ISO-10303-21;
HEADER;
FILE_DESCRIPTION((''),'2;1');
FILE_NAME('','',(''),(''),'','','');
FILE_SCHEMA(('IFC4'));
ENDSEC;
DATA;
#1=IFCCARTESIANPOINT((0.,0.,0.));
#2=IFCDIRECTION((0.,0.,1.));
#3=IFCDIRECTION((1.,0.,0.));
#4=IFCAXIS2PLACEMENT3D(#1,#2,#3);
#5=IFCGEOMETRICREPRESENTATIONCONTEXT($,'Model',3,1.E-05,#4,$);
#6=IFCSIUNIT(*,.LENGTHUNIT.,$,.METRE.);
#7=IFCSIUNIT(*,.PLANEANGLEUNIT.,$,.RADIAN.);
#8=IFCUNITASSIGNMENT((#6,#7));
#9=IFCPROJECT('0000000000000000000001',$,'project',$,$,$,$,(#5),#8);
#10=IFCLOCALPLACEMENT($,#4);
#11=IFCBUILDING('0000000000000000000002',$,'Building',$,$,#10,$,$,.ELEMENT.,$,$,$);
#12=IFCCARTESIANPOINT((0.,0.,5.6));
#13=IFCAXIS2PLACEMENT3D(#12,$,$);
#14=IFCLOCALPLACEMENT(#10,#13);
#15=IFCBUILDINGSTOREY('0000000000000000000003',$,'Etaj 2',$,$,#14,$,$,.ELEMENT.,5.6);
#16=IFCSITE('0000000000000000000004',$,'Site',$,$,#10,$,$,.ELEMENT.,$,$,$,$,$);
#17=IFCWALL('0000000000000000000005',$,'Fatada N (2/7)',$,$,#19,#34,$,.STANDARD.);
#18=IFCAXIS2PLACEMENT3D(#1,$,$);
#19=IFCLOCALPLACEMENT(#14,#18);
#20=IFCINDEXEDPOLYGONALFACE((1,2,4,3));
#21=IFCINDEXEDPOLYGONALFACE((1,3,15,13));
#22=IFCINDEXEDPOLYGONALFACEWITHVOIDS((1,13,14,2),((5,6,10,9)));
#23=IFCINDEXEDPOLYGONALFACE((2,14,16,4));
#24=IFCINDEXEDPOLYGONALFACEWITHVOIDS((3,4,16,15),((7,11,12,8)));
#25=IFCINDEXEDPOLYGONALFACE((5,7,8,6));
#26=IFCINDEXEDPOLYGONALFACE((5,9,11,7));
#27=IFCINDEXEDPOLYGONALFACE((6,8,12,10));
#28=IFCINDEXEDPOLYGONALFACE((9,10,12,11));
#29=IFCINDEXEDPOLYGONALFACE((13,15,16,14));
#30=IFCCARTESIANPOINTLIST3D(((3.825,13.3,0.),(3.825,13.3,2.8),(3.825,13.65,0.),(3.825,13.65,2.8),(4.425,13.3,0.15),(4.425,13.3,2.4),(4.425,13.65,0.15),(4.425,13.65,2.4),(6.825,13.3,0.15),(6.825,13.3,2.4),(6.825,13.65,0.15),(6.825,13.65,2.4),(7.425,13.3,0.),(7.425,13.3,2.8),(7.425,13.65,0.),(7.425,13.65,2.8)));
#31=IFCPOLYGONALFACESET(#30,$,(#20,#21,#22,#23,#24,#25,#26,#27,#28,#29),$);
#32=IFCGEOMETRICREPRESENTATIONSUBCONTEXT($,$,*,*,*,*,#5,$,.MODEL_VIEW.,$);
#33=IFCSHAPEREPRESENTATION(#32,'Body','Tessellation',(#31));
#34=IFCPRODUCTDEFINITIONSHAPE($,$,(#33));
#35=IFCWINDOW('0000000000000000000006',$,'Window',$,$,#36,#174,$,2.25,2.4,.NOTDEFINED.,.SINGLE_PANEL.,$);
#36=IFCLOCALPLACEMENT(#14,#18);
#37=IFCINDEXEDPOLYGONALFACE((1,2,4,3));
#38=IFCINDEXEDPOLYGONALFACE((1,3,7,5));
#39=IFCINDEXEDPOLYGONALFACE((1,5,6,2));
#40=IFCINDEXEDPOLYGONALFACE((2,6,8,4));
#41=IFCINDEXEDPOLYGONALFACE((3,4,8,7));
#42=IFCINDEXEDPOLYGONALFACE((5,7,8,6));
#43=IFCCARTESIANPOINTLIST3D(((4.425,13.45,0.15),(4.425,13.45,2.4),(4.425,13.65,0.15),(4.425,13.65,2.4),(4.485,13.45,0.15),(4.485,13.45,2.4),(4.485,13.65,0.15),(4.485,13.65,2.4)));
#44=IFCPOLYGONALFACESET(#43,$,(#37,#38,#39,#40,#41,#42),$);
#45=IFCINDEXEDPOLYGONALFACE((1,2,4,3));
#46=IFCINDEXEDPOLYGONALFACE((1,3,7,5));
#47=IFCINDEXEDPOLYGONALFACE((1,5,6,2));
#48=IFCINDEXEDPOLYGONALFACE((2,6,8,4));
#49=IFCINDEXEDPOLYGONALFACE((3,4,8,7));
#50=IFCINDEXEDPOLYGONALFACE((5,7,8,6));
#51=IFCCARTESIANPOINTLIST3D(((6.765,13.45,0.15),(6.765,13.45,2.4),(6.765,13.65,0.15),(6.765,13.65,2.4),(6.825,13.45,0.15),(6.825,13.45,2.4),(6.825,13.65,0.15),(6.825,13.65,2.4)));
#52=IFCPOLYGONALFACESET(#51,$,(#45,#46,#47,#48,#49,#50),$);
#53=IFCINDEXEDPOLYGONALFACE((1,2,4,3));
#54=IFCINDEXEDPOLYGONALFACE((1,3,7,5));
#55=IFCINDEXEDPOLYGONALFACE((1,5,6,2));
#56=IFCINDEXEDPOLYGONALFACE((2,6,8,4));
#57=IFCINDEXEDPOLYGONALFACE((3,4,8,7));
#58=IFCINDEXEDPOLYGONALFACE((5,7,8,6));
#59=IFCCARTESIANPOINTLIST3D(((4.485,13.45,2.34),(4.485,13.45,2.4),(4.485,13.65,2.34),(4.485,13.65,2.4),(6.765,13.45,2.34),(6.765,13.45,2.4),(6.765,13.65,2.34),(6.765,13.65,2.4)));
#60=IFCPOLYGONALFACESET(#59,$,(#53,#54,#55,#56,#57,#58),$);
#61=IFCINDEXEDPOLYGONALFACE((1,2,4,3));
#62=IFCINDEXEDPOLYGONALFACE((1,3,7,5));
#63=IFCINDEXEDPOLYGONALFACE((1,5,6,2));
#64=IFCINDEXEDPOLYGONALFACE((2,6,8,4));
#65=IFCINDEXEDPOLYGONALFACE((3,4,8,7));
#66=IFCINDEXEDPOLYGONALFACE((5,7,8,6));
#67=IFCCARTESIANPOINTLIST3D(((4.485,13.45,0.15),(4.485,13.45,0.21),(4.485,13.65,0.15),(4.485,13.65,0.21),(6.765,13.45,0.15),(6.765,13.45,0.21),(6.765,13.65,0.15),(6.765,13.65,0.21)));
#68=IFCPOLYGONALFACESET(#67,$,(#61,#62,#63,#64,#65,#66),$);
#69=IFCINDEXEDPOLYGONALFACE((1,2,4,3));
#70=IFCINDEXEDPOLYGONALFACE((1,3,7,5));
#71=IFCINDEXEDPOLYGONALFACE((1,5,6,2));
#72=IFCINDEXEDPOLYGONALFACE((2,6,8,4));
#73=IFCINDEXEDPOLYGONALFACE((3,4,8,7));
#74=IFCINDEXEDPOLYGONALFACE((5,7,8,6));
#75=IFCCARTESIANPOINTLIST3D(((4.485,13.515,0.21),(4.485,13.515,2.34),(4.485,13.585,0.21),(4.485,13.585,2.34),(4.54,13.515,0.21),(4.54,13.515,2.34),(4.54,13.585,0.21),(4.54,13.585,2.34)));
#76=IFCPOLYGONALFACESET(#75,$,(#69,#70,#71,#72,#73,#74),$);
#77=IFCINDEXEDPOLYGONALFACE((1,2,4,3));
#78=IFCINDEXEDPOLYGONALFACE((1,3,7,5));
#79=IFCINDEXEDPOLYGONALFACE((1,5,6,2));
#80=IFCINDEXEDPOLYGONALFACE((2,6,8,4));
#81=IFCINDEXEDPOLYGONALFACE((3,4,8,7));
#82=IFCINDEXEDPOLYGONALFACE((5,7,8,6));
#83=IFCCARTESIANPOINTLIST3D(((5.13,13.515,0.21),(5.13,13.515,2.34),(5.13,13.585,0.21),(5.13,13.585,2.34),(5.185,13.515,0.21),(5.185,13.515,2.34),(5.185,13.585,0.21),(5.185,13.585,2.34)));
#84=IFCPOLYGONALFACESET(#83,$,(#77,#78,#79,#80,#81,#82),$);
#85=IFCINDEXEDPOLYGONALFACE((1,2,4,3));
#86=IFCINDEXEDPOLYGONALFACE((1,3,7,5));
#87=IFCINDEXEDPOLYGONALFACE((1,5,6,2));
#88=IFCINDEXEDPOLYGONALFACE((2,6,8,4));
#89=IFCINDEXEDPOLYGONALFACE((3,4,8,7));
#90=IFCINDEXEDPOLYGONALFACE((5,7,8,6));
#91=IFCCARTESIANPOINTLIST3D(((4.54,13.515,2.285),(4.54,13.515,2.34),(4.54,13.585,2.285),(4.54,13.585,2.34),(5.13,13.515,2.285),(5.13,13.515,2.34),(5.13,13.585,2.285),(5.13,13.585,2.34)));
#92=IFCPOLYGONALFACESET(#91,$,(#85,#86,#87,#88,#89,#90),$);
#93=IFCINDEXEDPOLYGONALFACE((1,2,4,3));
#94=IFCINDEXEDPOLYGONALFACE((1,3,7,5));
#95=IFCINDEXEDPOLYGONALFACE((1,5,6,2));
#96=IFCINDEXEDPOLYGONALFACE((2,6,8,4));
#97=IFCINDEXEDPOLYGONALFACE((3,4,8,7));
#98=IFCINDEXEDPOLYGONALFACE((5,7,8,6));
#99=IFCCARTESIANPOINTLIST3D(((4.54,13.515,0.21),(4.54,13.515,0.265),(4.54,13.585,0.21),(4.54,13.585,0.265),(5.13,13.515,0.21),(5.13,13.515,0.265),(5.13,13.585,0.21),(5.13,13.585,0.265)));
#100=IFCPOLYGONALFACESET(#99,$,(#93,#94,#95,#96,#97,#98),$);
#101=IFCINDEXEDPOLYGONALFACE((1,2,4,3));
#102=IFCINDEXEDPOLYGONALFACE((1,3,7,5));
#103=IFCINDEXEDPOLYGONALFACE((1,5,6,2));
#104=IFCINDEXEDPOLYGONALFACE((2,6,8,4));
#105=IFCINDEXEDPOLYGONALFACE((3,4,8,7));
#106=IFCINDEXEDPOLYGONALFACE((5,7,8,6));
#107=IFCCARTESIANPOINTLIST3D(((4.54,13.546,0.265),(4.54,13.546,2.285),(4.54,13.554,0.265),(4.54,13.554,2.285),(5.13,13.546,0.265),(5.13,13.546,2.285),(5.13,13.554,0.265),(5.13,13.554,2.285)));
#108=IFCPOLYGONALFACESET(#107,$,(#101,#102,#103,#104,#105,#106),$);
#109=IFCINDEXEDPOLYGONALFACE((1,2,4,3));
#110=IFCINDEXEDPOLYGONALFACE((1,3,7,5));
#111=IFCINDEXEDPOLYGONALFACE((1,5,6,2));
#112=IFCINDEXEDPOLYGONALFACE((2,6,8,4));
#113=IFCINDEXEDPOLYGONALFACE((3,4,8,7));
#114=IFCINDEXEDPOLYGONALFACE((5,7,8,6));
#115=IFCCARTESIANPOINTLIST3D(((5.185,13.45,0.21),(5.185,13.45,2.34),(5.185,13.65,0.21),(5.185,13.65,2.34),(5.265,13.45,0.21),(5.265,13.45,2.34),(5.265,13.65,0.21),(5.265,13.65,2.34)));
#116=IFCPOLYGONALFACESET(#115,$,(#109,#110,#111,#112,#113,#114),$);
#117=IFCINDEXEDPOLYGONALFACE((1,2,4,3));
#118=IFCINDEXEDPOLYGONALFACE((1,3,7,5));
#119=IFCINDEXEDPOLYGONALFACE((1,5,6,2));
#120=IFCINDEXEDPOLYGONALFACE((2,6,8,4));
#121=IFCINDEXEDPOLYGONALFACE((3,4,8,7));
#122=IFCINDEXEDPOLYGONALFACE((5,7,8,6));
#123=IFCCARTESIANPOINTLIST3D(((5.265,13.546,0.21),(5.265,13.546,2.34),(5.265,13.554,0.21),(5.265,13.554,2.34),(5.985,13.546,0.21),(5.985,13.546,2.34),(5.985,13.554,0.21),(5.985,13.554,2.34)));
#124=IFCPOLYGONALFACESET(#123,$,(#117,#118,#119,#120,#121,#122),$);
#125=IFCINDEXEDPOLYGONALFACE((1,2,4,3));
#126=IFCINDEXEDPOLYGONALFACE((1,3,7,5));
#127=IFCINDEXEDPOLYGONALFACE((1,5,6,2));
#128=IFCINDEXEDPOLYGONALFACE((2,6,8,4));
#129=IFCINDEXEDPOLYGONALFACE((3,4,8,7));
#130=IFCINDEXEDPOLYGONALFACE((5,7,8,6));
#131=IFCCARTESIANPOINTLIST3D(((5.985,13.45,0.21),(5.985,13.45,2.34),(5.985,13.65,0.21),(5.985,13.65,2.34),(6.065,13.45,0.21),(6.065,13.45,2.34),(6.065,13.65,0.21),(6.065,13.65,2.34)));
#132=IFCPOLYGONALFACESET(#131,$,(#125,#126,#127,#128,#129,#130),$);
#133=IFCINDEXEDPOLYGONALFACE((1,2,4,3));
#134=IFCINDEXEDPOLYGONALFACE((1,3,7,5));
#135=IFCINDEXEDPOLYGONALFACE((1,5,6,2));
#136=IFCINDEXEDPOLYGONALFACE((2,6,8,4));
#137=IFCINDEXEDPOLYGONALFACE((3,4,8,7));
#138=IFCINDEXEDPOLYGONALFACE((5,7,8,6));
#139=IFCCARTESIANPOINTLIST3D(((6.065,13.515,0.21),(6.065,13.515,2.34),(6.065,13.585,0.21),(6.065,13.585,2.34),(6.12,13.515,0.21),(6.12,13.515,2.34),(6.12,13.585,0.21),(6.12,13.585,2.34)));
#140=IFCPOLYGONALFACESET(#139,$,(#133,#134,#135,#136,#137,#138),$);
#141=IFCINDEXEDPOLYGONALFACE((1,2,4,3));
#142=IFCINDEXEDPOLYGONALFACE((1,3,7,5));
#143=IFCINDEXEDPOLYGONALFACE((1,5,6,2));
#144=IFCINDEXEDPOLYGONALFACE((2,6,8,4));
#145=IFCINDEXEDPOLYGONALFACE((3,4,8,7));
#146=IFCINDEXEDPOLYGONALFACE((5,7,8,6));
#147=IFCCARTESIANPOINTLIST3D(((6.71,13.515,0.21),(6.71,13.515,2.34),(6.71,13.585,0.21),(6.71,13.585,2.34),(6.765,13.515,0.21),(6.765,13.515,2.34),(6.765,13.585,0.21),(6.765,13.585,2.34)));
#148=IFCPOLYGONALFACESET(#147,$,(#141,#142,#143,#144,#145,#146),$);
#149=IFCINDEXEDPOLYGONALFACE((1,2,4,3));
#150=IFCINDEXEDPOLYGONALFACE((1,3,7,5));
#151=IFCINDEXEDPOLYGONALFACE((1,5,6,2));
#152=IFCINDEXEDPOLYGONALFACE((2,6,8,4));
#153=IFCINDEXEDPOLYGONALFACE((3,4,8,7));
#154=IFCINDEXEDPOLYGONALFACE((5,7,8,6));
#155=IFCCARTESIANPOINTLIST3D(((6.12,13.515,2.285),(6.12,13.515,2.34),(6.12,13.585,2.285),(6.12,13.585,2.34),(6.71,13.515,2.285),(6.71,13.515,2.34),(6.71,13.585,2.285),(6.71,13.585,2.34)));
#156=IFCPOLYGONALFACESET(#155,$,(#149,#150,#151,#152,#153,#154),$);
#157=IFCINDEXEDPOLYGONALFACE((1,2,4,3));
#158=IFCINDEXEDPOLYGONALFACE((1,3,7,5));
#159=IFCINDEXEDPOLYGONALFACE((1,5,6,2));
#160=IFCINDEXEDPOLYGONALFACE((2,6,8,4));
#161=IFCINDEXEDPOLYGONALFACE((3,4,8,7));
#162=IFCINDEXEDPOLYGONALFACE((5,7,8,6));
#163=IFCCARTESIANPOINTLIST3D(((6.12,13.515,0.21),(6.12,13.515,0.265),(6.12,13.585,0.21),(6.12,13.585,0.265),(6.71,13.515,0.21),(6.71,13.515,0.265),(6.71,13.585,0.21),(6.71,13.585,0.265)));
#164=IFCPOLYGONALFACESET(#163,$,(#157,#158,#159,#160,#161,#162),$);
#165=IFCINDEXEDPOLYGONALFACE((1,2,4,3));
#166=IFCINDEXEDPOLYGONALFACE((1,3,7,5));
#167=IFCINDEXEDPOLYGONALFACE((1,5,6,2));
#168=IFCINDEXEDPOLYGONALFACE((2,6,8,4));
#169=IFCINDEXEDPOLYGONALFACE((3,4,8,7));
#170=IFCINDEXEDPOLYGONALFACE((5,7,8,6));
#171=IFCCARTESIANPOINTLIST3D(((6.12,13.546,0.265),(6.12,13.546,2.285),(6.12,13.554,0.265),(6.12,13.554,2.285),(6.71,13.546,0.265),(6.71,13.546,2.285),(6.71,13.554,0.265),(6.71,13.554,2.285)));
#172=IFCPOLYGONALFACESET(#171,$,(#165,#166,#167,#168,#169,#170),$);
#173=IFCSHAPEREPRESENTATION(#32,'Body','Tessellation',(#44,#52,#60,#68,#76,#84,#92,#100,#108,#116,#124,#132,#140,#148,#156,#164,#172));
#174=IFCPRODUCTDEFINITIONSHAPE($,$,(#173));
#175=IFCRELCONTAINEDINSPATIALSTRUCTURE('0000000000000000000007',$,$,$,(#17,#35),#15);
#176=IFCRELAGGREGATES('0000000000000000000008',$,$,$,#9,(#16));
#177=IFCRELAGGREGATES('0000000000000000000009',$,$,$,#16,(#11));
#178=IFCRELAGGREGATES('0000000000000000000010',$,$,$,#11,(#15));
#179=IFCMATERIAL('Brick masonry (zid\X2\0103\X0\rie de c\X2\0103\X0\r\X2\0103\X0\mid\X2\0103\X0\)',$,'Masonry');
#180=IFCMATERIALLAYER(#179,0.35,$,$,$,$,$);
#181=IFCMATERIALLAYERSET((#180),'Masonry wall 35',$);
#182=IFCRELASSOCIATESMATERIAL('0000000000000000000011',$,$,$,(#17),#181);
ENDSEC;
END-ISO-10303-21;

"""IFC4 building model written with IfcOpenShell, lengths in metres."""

from ifc_helpers import new_model, si_unit, frame, frame_2d, origin, origin_with_axes, origin_2d, place, context, subcontext, project, spatial, rectangle, extrude, material, layer, layer_set, layer_usage, element, fill, save


model = new_model("IFC4")

# Units and contexts
model_context = context("Model", 3, precision=1e-05, world=origin_with_axes())
sub_context = subcontext(model_context, None, None, "MODEL_VIEW")
ifc_project = project(units=[si_unit("LENGTHUNIT", "METRE"), si_unit("PLANEANGLEUNIT", "RADIAN")], contexts=[model_context])

# Site, building, storey
placement = place(None, origin_with_axes())
site = spatial("IfcSite", under=ifc_project, at=placement, Name="Site", CompositionType="ELEMENT")
building = spatial("IfcBuilding", under=site, at=placement, Name="Building", CompositionType="ELEMENT")
storey_placement = place(placement, frame((0.0, 0.0, 5.6)))
storey = spatial("IfcBuildingStorey", under=building, at=storey_placement, Name="Etaj 2", CompositionType="ELEMENT", Elevation=5.6)

# Wall, opening, window
ifc_material_1 = material(Name="Brick masonry (zidărie de cărămidă)", Category="Masonry")
ifc_layer_1 = layer(ifc_material_1, 0.35)
ifc_layer_set_1 = layer_set([ifc_layer_1], Name="Masonry wall 35")
ifc_layer_usage_1 = layer_usage(ifc_layer_set_1, "AXIS2", "POSITIVE", -0.175)
wall_1_placement = place(storey_placement, frame((3.825, 13.475, 0.0), x_axis=(1.0, 0.0, 0.0)))
wall_1 = element("IfcWall", 1, at=wall_1_placement, inside=storey, material=ifc_layer_usage_1, Name="Fatada N (2/7)", PredefinedType="STANDARD", context=sub_context, shape_type="SweptSolid", body=[
    extrude(rectangle(XDim=3.6, YDim=0.35, at=frame_2d((1.8, 0.0))), origin(), (0.0, 0.0, 1.0), 2.8),
])
opening_1_placement = place(wall_1_placement, frame((1.8, 0.225, 0.15), z_axis=(0.0, -1.0, 0.0), x_axis=(1.0, 0.0, 0.0)))
opening_1 = element("IfcOpeningElement", 2, at=opening_1_placement, cuts=wall_1, PredefinedType="OPENING", context=sub_context, shape_type="SweptSolid", body=[
    extrude(rectangle(XDim=2.4, YDim=2.25, at=frame_2d((0.0, 1.125))), origin(), (0.0, 0.0, 1.0), 0.45),
])
window_1_placement = place(wall_1_placement, frame((1.8, 0.175, 0.15), z_axis=(0.0, -1.0, 0.0), x_axis=(1.0, 0.0, 0.0)))
window_1 = element("IfcWindow", 3, at=window_1_placement, inside=storey, Name="Window", OverallHeight=2.25, OverallWidth=2.4, PartitioningType="SINGLE_PANEL", PredefinedType="NOTDEFINED", context=sub_context, shape_type="SweptSolid", body=[
    extrude(rectangle(XDim=0.06, YDim=2.25, at=origin_2d()), frame((-1.17, 1.125, 0.0)), (0.0, 0.0, 1.0), 0.2),
    extrude(rectangle(XDim=0.06, YDim=2.25, at=origin_2d()), frame((1.17, 1.125, 0.0)), (0.0, 0.0, 1.0), 0.2),
    extrude(rectangle(XDim=2.28, YDim=0.06, at=origin_2d()), frame((0.0, 2.22, 0.0)), (0.0, 0.0, 1.0), 0.2),
    extrude(rectangle(XDim=2.28, YDim=0.06, at=origin_2d()), frame((0.0, 0.03, 0.0)), (0.0, 0.0, 1.0), 0.2),
    extrude(rectangle(XDim=0.055, YDim=2.13, at=origin_2d()), frame((-1.1125, 1.125, 0.065)), (0.0, 0.0, 1.0), 0.07),
    extrude(rectangle(XDim=0.055, YDim=2.13, at=origin_2d()), frame((-0.4675, 1.125, 0.065)), (0.0, 0.0, 1.0), 0.07),
    extrude(rectangle(XDim=0.59, YDim=0.055, at=origin_2d()), frame((-0.79, 2.1625, 0.065)), (0.0, 0.0, 1.0), 0.07),
    extrude(rectangle(XDim=0.59, YDim=0.055, at=origin_2d()), frame((-0.79, 0.0875, 0.065)), (0.0, 0.0, 1.0), 0.07),
    extrude(rectangle(XDim=0.59, YDim=2.02, at=origin_2d()), frame((-0.79, 1.125, 0.096)), (0.0, 0.0, 1.0), 0.008),
    extrude(rectangle(XDim=0.08, YDim=2.13, at=origin_2d()), frame((-0.4, 1.125, 0.0)), (0.0, 0.0, 1.0), 0.2),
    extrude(rectangle(XDim=0.72, YDim=2.13, at=origin_2d()), frame((0.0, 1.125, 0.096)), (0.0, 0.0, 1.0), 0.008),
    extrude(rectangle(XDim=0.08, YDim=2.13, at=origin_2d()), frame((0.4, 1.125, 0.0)), (0.0, 0.0, 1.0), 0.2),
    extrude(rectangle(XDim=0.055, YDim=2.13, at=origin_2d()), frame((0.4675, 1.125, 0.065)), (0.0, 0.0, 1.0), 0.07),
    extrude(rectangle(XDim=0.055, YDim=2.13, at=origin_2d()), frame((1.1125, 1.125, 0.065)), (0.0, 0.0, 1.0), 0.07),
    extrude(rectangle(XDim=0.59, YDim=0.055, at=origin_2d()), frame((0.79, 2.1625, 0.065)), (0.0, 0.0, 1.0), 0.07),
    extrude(rectangle(XDim=0.59, YDim=0.055, at=origin_2d()), frame((0.79, 0.0875, 0.065)), (0.0, 0.0, 1.0), 0.07),
    extrude(rectangle(XDim=0.59, YDim=2.02, at=origin_2d()), frame((0.79, 1.125, 0.096)), (0.0, 0.0, 1.0), 0.008),
])
fill(opening_1, window_1)

save(model, "model.ifc")
